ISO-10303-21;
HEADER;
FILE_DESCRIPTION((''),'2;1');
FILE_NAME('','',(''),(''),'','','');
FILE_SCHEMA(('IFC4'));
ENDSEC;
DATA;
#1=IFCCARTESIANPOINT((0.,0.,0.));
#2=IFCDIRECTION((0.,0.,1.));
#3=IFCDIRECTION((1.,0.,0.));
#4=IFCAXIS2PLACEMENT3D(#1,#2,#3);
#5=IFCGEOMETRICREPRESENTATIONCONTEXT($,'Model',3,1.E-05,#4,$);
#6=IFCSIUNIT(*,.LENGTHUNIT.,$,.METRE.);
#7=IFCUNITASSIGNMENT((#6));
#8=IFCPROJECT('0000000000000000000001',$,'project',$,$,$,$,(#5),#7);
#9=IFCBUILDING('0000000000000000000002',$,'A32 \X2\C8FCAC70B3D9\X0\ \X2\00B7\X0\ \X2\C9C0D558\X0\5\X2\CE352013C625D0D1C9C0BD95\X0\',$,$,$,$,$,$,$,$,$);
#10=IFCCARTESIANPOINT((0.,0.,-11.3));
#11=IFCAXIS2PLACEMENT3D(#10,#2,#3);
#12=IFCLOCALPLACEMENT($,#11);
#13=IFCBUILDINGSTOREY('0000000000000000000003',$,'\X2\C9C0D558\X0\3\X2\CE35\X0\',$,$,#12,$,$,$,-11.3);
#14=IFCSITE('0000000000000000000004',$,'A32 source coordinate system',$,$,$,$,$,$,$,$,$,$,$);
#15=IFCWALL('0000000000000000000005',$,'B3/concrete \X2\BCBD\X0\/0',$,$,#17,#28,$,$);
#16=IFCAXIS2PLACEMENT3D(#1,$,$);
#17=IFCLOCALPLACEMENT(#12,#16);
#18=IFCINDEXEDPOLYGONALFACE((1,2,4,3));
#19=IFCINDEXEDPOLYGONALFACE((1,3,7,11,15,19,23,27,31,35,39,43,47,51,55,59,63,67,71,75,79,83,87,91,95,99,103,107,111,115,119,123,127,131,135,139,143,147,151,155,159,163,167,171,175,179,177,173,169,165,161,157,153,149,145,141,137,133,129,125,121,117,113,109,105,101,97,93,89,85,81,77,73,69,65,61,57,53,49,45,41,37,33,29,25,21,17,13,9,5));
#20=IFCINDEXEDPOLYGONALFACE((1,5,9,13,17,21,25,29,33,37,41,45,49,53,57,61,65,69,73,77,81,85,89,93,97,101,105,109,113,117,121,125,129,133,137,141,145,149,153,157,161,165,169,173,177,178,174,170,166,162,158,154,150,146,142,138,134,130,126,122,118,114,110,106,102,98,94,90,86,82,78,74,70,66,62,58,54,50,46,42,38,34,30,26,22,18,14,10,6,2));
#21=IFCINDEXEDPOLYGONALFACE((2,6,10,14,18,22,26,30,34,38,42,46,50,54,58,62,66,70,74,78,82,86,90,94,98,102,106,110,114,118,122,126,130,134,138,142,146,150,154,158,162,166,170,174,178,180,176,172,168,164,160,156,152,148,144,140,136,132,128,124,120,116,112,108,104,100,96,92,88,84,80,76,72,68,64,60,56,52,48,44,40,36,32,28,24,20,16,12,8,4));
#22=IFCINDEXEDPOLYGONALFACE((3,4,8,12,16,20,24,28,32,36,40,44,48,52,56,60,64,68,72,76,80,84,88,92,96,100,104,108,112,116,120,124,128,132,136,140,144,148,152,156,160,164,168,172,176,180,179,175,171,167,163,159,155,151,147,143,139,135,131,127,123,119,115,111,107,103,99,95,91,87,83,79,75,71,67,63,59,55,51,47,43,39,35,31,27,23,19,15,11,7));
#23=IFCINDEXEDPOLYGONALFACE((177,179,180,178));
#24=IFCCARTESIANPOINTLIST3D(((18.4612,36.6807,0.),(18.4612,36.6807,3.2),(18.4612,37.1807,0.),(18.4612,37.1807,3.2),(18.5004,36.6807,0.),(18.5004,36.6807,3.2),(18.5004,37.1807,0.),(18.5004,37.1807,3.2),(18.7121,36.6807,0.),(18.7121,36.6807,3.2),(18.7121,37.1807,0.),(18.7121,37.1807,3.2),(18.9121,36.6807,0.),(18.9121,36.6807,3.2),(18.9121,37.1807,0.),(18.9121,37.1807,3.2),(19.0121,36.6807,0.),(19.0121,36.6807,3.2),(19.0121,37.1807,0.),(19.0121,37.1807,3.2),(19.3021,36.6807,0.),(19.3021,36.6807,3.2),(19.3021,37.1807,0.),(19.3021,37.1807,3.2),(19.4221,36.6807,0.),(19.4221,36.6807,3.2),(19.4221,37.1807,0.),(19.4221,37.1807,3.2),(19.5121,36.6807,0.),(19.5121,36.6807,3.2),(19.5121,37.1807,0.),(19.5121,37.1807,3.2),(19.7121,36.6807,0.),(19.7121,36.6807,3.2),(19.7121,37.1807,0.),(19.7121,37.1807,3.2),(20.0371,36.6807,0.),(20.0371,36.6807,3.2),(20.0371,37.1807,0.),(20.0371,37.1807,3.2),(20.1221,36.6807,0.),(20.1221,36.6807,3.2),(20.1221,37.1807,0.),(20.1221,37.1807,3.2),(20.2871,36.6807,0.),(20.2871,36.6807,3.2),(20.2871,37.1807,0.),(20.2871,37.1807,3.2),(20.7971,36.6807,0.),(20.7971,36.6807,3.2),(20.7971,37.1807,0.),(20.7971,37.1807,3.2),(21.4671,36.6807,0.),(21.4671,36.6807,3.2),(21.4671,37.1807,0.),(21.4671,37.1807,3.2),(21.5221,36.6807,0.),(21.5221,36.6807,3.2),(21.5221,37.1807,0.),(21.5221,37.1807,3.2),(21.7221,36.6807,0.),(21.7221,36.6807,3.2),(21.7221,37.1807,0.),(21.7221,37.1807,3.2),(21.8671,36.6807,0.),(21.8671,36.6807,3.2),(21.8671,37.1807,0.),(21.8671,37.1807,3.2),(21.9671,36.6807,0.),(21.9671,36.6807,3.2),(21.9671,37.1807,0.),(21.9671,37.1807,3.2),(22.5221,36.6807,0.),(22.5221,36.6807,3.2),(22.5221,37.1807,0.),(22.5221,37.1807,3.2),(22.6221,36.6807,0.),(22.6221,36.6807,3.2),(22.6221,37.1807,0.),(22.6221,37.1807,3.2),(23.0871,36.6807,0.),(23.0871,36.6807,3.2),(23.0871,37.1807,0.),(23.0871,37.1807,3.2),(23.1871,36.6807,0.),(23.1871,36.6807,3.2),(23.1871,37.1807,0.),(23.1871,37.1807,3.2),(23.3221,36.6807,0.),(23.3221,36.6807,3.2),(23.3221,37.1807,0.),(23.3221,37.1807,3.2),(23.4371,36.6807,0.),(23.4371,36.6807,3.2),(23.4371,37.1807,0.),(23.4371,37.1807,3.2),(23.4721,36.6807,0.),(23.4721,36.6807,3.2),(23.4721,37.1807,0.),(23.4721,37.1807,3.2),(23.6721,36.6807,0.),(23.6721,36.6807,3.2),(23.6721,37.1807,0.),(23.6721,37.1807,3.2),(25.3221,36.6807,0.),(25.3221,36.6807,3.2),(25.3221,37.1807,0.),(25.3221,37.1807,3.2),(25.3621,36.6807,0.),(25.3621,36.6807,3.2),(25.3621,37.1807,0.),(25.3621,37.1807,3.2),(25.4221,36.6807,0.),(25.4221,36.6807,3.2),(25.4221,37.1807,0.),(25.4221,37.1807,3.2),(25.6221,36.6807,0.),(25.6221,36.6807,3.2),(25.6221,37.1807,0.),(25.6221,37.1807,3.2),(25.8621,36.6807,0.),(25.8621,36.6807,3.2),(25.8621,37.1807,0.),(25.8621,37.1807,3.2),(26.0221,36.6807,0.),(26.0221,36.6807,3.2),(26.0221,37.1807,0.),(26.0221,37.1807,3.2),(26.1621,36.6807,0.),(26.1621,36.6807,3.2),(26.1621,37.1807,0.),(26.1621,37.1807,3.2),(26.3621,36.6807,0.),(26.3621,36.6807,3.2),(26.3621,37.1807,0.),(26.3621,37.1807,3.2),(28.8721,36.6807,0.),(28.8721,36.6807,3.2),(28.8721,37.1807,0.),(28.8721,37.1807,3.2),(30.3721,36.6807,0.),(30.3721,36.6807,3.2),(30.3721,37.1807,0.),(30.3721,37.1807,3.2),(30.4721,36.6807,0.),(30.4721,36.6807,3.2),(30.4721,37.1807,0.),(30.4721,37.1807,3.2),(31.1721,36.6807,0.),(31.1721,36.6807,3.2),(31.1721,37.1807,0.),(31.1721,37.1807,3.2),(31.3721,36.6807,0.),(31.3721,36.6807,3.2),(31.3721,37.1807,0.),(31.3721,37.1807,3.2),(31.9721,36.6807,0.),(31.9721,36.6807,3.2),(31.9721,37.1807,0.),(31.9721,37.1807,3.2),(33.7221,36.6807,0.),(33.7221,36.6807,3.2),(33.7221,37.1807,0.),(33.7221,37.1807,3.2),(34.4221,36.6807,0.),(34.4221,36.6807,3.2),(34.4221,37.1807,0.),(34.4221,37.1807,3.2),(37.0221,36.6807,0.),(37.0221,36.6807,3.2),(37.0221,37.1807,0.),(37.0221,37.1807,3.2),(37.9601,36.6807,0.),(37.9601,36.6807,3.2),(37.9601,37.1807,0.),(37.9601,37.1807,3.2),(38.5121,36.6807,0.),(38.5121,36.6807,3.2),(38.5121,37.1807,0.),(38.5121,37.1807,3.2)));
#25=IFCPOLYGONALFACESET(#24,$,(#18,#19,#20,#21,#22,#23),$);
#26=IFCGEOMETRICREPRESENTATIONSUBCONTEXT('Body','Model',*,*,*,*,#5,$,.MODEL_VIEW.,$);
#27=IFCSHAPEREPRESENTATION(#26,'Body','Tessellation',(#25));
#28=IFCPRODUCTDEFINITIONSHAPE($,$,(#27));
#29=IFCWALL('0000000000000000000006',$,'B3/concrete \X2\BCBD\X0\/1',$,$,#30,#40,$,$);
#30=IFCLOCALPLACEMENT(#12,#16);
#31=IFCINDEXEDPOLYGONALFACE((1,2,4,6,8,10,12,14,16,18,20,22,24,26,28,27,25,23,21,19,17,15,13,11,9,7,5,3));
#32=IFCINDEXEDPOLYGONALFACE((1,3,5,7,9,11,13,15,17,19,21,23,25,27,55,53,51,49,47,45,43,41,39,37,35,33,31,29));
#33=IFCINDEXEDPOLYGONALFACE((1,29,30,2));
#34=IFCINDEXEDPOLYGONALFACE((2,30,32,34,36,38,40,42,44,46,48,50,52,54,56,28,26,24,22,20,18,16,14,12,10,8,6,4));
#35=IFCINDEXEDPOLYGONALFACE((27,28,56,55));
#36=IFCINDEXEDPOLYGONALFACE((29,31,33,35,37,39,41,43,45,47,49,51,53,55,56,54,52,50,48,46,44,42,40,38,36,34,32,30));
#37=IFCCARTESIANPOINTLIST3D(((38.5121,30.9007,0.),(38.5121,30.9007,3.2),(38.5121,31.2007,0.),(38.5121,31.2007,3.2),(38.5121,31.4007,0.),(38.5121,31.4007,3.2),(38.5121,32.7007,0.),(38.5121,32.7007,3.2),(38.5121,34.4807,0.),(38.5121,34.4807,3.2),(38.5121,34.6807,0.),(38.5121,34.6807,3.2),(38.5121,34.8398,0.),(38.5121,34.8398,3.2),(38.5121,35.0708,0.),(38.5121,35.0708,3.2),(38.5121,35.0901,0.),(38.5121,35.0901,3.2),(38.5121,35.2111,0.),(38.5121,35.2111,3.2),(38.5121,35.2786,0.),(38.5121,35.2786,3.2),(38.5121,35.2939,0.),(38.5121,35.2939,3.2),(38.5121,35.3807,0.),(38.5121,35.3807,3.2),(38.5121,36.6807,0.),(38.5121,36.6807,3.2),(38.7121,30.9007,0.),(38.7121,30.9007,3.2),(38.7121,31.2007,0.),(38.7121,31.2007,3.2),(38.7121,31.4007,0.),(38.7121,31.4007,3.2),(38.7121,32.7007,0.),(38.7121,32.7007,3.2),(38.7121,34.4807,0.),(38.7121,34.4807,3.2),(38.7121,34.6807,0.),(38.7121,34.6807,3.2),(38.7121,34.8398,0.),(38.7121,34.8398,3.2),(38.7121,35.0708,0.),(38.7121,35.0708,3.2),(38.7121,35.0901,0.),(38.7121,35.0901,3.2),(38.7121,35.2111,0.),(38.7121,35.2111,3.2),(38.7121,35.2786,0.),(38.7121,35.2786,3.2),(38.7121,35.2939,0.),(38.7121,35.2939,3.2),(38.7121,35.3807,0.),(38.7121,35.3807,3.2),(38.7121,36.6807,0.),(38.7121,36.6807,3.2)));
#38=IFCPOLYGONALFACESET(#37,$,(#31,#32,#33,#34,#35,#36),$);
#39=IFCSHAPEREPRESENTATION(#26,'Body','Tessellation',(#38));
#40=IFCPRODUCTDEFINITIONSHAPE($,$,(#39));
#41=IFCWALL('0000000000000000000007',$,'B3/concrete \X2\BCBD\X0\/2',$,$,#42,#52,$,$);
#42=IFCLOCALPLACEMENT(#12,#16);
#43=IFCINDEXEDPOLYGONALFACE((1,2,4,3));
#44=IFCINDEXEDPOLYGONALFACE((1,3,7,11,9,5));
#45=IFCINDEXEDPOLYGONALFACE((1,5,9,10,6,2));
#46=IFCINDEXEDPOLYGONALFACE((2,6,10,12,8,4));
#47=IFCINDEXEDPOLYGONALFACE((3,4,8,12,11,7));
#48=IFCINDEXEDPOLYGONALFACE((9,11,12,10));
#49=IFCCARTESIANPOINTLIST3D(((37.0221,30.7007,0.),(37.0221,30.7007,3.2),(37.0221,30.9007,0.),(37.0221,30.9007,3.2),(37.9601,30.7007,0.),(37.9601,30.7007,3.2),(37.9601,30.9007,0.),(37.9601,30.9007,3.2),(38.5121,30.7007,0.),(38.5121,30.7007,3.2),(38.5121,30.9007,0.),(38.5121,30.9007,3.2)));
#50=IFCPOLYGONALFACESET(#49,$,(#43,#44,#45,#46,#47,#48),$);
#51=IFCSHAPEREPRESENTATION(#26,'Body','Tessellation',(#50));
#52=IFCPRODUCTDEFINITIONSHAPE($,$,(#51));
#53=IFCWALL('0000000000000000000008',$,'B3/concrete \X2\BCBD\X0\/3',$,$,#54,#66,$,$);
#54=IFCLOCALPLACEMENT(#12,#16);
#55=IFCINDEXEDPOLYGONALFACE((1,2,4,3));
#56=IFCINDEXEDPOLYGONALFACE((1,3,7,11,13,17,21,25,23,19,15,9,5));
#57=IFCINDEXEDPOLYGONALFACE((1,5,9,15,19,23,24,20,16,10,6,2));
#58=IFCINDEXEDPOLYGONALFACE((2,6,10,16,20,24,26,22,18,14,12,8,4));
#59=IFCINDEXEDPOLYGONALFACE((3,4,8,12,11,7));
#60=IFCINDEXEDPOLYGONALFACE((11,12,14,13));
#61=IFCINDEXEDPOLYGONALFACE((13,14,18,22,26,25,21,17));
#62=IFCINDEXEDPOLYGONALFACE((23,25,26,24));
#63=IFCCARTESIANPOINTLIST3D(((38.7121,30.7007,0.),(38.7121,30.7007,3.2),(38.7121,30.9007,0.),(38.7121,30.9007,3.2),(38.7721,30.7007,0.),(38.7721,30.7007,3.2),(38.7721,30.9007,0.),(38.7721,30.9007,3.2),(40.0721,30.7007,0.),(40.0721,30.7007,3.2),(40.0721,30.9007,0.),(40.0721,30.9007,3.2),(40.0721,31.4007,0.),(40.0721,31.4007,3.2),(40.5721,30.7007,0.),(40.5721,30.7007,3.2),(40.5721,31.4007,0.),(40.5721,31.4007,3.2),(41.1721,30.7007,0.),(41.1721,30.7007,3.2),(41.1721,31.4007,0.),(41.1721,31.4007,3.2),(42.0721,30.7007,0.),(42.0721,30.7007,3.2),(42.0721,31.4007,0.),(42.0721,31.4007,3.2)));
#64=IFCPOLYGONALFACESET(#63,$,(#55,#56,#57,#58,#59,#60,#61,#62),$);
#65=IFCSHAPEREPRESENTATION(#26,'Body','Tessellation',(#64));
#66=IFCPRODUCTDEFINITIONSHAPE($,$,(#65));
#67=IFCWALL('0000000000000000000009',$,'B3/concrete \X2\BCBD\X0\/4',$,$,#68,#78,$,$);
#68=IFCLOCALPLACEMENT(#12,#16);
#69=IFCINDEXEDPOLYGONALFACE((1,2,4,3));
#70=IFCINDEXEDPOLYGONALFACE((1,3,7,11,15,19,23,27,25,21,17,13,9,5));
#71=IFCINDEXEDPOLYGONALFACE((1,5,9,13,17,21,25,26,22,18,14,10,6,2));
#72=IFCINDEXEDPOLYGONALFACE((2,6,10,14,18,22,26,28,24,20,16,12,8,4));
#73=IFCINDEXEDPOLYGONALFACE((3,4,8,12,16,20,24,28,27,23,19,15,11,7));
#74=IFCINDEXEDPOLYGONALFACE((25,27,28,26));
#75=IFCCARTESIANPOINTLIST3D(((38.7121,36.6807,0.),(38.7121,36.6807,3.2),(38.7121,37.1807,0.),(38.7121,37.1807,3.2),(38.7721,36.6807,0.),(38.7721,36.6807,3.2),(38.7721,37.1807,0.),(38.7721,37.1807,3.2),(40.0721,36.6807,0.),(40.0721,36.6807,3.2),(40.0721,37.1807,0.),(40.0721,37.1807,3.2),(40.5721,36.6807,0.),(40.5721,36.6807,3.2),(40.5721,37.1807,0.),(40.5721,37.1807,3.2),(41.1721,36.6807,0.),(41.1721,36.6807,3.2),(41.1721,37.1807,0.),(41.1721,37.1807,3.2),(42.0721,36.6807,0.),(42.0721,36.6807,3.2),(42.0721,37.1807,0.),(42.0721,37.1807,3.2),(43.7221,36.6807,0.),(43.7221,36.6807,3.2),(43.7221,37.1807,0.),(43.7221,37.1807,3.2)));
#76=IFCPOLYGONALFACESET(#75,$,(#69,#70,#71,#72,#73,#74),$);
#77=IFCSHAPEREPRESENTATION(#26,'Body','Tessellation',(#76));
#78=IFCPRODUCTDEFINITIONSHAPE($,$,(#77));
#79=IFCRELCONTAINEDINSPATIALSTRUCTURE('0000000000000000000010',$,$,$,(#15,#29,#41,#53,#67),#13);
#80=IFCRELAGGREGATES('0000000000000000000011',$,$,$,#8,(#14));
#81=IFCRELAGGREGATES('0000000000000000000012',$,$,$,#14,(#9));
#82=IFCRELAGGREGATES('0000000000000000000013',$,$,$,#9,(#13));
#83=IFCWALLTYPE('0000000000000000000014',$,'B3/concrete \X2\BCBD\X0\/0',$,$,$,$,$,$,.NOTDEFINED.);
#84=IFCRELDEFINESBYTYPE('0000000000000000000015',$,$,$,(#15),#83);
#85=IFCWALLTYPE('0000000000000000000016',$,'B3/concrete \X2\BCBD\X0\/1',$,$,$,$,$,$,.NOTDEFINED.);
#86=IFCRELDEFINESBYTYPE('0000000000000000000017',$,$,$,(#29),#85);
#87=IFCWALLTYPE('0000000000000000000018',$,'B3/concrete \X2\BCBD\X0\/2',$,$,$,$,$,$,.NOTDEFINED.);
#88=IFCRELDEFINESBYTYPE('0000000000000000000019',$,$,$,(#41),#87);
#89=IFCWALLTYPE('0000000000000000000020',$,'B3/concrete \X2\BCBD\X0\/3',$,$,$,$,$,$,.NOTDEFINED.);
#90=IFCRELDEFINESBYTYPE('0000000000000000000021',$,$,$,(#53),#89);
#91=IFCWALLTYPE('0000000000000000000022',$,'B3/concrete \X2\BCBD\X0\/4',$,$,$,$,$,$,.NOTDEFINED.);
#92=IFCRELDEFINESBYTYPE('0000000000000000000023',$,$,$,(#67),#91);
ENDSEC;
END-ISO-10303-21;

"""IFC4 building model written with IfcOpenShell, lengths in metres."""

from ifc_helpers import new_model, si_unit, frame, origin, origin_with_axes, place, context, subcontext, project, spatial, polyline, outline, extrude, source, transform, mapped, type_object, type_shapes, element, save


model = new_model("IFC4")

# Units and contexts
model_context = context("Model", 3, precision=1e-05, world=origin_with_axes())
body_context = subcontext(model_context, "Body", "Model", "MODEL_VIEW")
ifc_project = project(units=[si_unit("LENGTHUNIT", "METRE")], contexts=[model_context])

# Site, building, storey
site = spatial("IfcSite", under=ifc_project, Name="A32 source coordinate system")
building = spatial("IfcBuilding", under=site, Name="A32 주거동 · 지하5층–옥탑지붕")
storey_placement = place(None, frame((0.0, 0.0, -11.3), z_axis=(0.0, 0.0, 1.0), x_axis=(1.0, 0.0, 0.0)))
storey = spatial("IfcBuildingStorey", under=building, at=storey_placement, Name="지하3층", Elevation=-11.3)

# Walls
wall_type_1 = type_object("IfcWallType", Name="B3/concrete 벽/0", PredefinedType="NOTDEFINED")
shared_shape_1 = source(origin(), body_context, "Body", "SweptSolid", [
    extrude(outline(polyline([(18.9121, 37.1807), (19.0121, 37.1807), (19.3021, 37.1807), (19.4221, 37.1807), (19.5121, 37.1807), (19.7121, 37.1807), (20.0371, 37.1807), (20.1221, 37.1807), (20.2871, 37.1807), (20.7971, 37.1807), (21.4671, 37.1807), (21.5221, 37.1807), (21.7221, 37.1807), (21.8671, 37.1807), (21.9671, 37.1807), (22.5221, 37.1807), (22.6221, 37.1807), (23.0871, 37.1807), (23.1871, 37.1807), (23.3221, 37.1807), (23.4371, 37.1807), (23.4721, 37.1807), (23.6721, 37.1807), (25.3221, 37.1807), (25.3621, 37.1807), (25.4221, 37.1807), (25.6221, 37.1807), (25.8621, 37.1807), (26.0221, 37.1807), (26.1621, 37.1807), (26.3621, 37.1807), (28.8721, 37.1807), (30.3721, 37.1807), (30.4721, 37.1807), (31.1721, 37.1807), (31.3721, 37.1807), (31.9721, 37.1807), (33.7221, 37.1807), (34.4221, 37.1807), (37.0221, 37.1807), (37.9601, 37.1807), (38.5121, 37.1807), (38.5121, 36.6807), (37.9601, 36.6807), (37.0221, 36.6807), (34.4221, 36.6807), (33.7221, 36.6807), (31.9721, 36.6807), (31.3721, 36.6807), (31.1721, 36.6807), (30.4721, 36.6807), (30.3721, 36.6807), (28.8721, 36.6807), (26.3621, 36.6807), (26.1621, 36.6807), (26.0221, 36.6807), (25.8621, 36.6807), (25.6221, 36.6807), (25.4221, 36.6807), (25.3621, 36.6807), (25.3221, 36.6807), (23.6721, 36.6807), (23.4721, 36.6807), (23.4371, 36.6807), (23.3221, 36.6807), (23.1871, 36.6807), (23.0871, 36.6807), (22.6221, 36.6807), (22.5221, 36.6807), (21.9671, 36.6807), (21.8671, 36.6807), (21.7221, 36.6807), (21.5221, 36.6807), (21.4671, 36.6807), (20.7971, 36.6807), (20.2871, 36.6807), (20.1221, 36.6807), (20.0371, 36.6807), (19.7121, 36.6807), (19.5121, 36.6807), (19.4221, 36.6807), (19.3021, 36.6807), (19.0121, 36.6807), (18.9121, 36.6807), (18.7121, 36.6807), (18.5004, 36.6807), (18.4612, 36.6807), (18.4612, 37.1807), (18.5004, 37.1807), (18.7121, 37.1807), (18.9121, 37.1807)])), origin(), (0.0, 0.0, 1.0), 3.2),
])
type_shapes(wall_type_1, [shared_shape_1])
wall_1_placement = place(storey_placement, origin_with_axes())
element("IfcWall", 1, at=wall_1_placement, inside=storey, type_object=wall_type_1, Name="B3/concrete 벽/0", context=body_context, shape_type="MappedRepresentation", body=[
    mapped(shared_shape_1, transform((0.0, 0.0, 0.0), scale=1.0)),
])
wall_type_2 = type_object("IfcWallType", Name="B3/concrete 벽/1", PredefinedType="NOTDEFINED")
shared_shape_2 = source(origin(), body_context, "Body", "SweptSolid", [
    extrude(outline(polyline([(38.7121, 35.2939), (38.7121, 35.2786), (38.7121, 35.2111), (38.7121, 35.0901), (38.7121, 35.0708), (38.7121, 34.8398), (38.7121, 34.6807), (38.7121, 34.4807), (38.7121, 32.7007), (38.7121, 31.4007), (38.7121, 31.2007), (38.7121, 30.9007), (38.5121, 30.9007), (38.5121, 31.2007), (38.5121, 31.4007), (38.5121, 32.7007), (38.5121, 34.4807), (38.5121, 34.6807), (38.5121, 34.8398), (38.5121, 35.0708), (38.5121, 35.0901), (38.5121, 35.2111), (38.5121, 35.2786), (38.5121, 35.2939), (38.5121, 35.3807), (38.5121, 36.6807), (38.7121, 36.6807), (38.7121, 35.3807), (38.7121, 35.2939)])), origin(), (0.0, 0.0, 1.0), 3.2),
])
type_shapes(wall_type_2, [shared_shape_2])
wall_2_placement = place(storey_placement, origin_with_axes())
element("IfcWall", 2, at=wall_2_placement, inside=storey, type_object=wall_type_2, Name="B3/concrete 벽/1", context=body_context, shape_type="MappedRepresentation", body=[
    mapped(shared_shape_2, transform((0.0, 0.0, 0.0), scale=1.0)),
])
wall_type_3 = type_object("IfcWallType", Name="B3/concrete 벽/2", PredefinedType="NOTDEFINED")
shared_shape_3 = source(origin(), body_context, "Body", "SweptSolid", [
    extrude(outline(polyline([(37.0221, 30.7007), (37.0221, 30.9007), (37.9601, 30.9007), (38.5121, 30.9007), (38.5121, 30.7007), (37.9601, 30.7007), (37.0221, 30.7007)])), origin(), (0.0, 0.0, 1.0), 3.2),
])
type_shapes(wall_type_3, [shared_shape_3])
wall_3_placement = place(storey_placement, origin_with_axes())
element("IfcWall", 3, at=wall_3_placement, inside=storey, type_object=wall_type_3, Name="B3/concrete 벽/2", context=body_context, shape_type="MappedRepresentation", body=[
    mapped(shared_shape_3, transform((0.0, 0.0, 0.0), scale=1.0)),
])
wall_type_4 = type_object("IfcWallType", Name="B3/concrete 벽/3", PredefinedType="NOTDEFINED")
shared_shape_4 = source(origin(), body_context, "Body", "SweptSolid", [
    extrude(outline(polyline([(40.0721, 31.4007), (40.5721, 31.4007), (41.1721, 31.4007), (42.0721, 31.4007), (42.0721, 30.7007), (41.1721, 30.7007), (40.5721, 30.7007), (40.0721, 30.7007), (38.7721, 30.7007), (38.7121, 30.7007), (38.7121, 30.9007), (38.7721, 30.9007), (40.0721, 30.9007), (40.0721, 31.4007)])), origin(), (0.0, 0.0, 1.0), 3.2),
])
type_shapes(wall_type_4, [shared_shape_4])
wall_4_placement = place(storey_placement, origin_with_axes())
element("IfcWall", 4, at=wall_4_placement, inside=storey, type_object=wall_type_4, Name="B3/concrete 벽/3", context=body_context, shape_type="MappedRepresentation", body=[
    mapped(shared_shape_4, transform((0.0, 0.0, 0.0), scale=1.0)),
])
wall_type_5 = type_object("IfcWallType", Name="B3/concrete 벽/4", PredefinedType="NOTDEFINED")
shared_shape_5 = source(origin(), body_context, "Body", "SweptSolid", [
    extrude(outline(polyline([(40.0721, 37.1807), (40.5721, 37.1807), (41.1721, 37.1807), (42.0721, 37.1807), (43.7221, 37.1807), (43.7221, 36.6807), (42.0721, 36.6807), (41.1721, 36.6807), (40.5721, 36.6807), (40.0721, 36.6807), (38.7721, 36.6807), (38.7121, 36.6807), (38.7121, 37.1807), (38.7721, 37.1807), (40.0721, 37.1807)])), origin(), (0.0, 0.0, 1.0), 3.2),
])
type_shapes(wall_type_5, [shared_shape_5])
wall_5_placement = place(storey_placement, origin_with_axes())
element("IfcWall", 5, at=wall_5_placement, inside=storey, type_object=wall_type_5, Name="B3/concrete 벽/4", context=body_context, shape_type="MappedRepresentation", body=[
    mapped(shared_shape_5, transform((0.0, 0.0, 0.0), scale=1.0)),
])

save(model, "model.ifc")
